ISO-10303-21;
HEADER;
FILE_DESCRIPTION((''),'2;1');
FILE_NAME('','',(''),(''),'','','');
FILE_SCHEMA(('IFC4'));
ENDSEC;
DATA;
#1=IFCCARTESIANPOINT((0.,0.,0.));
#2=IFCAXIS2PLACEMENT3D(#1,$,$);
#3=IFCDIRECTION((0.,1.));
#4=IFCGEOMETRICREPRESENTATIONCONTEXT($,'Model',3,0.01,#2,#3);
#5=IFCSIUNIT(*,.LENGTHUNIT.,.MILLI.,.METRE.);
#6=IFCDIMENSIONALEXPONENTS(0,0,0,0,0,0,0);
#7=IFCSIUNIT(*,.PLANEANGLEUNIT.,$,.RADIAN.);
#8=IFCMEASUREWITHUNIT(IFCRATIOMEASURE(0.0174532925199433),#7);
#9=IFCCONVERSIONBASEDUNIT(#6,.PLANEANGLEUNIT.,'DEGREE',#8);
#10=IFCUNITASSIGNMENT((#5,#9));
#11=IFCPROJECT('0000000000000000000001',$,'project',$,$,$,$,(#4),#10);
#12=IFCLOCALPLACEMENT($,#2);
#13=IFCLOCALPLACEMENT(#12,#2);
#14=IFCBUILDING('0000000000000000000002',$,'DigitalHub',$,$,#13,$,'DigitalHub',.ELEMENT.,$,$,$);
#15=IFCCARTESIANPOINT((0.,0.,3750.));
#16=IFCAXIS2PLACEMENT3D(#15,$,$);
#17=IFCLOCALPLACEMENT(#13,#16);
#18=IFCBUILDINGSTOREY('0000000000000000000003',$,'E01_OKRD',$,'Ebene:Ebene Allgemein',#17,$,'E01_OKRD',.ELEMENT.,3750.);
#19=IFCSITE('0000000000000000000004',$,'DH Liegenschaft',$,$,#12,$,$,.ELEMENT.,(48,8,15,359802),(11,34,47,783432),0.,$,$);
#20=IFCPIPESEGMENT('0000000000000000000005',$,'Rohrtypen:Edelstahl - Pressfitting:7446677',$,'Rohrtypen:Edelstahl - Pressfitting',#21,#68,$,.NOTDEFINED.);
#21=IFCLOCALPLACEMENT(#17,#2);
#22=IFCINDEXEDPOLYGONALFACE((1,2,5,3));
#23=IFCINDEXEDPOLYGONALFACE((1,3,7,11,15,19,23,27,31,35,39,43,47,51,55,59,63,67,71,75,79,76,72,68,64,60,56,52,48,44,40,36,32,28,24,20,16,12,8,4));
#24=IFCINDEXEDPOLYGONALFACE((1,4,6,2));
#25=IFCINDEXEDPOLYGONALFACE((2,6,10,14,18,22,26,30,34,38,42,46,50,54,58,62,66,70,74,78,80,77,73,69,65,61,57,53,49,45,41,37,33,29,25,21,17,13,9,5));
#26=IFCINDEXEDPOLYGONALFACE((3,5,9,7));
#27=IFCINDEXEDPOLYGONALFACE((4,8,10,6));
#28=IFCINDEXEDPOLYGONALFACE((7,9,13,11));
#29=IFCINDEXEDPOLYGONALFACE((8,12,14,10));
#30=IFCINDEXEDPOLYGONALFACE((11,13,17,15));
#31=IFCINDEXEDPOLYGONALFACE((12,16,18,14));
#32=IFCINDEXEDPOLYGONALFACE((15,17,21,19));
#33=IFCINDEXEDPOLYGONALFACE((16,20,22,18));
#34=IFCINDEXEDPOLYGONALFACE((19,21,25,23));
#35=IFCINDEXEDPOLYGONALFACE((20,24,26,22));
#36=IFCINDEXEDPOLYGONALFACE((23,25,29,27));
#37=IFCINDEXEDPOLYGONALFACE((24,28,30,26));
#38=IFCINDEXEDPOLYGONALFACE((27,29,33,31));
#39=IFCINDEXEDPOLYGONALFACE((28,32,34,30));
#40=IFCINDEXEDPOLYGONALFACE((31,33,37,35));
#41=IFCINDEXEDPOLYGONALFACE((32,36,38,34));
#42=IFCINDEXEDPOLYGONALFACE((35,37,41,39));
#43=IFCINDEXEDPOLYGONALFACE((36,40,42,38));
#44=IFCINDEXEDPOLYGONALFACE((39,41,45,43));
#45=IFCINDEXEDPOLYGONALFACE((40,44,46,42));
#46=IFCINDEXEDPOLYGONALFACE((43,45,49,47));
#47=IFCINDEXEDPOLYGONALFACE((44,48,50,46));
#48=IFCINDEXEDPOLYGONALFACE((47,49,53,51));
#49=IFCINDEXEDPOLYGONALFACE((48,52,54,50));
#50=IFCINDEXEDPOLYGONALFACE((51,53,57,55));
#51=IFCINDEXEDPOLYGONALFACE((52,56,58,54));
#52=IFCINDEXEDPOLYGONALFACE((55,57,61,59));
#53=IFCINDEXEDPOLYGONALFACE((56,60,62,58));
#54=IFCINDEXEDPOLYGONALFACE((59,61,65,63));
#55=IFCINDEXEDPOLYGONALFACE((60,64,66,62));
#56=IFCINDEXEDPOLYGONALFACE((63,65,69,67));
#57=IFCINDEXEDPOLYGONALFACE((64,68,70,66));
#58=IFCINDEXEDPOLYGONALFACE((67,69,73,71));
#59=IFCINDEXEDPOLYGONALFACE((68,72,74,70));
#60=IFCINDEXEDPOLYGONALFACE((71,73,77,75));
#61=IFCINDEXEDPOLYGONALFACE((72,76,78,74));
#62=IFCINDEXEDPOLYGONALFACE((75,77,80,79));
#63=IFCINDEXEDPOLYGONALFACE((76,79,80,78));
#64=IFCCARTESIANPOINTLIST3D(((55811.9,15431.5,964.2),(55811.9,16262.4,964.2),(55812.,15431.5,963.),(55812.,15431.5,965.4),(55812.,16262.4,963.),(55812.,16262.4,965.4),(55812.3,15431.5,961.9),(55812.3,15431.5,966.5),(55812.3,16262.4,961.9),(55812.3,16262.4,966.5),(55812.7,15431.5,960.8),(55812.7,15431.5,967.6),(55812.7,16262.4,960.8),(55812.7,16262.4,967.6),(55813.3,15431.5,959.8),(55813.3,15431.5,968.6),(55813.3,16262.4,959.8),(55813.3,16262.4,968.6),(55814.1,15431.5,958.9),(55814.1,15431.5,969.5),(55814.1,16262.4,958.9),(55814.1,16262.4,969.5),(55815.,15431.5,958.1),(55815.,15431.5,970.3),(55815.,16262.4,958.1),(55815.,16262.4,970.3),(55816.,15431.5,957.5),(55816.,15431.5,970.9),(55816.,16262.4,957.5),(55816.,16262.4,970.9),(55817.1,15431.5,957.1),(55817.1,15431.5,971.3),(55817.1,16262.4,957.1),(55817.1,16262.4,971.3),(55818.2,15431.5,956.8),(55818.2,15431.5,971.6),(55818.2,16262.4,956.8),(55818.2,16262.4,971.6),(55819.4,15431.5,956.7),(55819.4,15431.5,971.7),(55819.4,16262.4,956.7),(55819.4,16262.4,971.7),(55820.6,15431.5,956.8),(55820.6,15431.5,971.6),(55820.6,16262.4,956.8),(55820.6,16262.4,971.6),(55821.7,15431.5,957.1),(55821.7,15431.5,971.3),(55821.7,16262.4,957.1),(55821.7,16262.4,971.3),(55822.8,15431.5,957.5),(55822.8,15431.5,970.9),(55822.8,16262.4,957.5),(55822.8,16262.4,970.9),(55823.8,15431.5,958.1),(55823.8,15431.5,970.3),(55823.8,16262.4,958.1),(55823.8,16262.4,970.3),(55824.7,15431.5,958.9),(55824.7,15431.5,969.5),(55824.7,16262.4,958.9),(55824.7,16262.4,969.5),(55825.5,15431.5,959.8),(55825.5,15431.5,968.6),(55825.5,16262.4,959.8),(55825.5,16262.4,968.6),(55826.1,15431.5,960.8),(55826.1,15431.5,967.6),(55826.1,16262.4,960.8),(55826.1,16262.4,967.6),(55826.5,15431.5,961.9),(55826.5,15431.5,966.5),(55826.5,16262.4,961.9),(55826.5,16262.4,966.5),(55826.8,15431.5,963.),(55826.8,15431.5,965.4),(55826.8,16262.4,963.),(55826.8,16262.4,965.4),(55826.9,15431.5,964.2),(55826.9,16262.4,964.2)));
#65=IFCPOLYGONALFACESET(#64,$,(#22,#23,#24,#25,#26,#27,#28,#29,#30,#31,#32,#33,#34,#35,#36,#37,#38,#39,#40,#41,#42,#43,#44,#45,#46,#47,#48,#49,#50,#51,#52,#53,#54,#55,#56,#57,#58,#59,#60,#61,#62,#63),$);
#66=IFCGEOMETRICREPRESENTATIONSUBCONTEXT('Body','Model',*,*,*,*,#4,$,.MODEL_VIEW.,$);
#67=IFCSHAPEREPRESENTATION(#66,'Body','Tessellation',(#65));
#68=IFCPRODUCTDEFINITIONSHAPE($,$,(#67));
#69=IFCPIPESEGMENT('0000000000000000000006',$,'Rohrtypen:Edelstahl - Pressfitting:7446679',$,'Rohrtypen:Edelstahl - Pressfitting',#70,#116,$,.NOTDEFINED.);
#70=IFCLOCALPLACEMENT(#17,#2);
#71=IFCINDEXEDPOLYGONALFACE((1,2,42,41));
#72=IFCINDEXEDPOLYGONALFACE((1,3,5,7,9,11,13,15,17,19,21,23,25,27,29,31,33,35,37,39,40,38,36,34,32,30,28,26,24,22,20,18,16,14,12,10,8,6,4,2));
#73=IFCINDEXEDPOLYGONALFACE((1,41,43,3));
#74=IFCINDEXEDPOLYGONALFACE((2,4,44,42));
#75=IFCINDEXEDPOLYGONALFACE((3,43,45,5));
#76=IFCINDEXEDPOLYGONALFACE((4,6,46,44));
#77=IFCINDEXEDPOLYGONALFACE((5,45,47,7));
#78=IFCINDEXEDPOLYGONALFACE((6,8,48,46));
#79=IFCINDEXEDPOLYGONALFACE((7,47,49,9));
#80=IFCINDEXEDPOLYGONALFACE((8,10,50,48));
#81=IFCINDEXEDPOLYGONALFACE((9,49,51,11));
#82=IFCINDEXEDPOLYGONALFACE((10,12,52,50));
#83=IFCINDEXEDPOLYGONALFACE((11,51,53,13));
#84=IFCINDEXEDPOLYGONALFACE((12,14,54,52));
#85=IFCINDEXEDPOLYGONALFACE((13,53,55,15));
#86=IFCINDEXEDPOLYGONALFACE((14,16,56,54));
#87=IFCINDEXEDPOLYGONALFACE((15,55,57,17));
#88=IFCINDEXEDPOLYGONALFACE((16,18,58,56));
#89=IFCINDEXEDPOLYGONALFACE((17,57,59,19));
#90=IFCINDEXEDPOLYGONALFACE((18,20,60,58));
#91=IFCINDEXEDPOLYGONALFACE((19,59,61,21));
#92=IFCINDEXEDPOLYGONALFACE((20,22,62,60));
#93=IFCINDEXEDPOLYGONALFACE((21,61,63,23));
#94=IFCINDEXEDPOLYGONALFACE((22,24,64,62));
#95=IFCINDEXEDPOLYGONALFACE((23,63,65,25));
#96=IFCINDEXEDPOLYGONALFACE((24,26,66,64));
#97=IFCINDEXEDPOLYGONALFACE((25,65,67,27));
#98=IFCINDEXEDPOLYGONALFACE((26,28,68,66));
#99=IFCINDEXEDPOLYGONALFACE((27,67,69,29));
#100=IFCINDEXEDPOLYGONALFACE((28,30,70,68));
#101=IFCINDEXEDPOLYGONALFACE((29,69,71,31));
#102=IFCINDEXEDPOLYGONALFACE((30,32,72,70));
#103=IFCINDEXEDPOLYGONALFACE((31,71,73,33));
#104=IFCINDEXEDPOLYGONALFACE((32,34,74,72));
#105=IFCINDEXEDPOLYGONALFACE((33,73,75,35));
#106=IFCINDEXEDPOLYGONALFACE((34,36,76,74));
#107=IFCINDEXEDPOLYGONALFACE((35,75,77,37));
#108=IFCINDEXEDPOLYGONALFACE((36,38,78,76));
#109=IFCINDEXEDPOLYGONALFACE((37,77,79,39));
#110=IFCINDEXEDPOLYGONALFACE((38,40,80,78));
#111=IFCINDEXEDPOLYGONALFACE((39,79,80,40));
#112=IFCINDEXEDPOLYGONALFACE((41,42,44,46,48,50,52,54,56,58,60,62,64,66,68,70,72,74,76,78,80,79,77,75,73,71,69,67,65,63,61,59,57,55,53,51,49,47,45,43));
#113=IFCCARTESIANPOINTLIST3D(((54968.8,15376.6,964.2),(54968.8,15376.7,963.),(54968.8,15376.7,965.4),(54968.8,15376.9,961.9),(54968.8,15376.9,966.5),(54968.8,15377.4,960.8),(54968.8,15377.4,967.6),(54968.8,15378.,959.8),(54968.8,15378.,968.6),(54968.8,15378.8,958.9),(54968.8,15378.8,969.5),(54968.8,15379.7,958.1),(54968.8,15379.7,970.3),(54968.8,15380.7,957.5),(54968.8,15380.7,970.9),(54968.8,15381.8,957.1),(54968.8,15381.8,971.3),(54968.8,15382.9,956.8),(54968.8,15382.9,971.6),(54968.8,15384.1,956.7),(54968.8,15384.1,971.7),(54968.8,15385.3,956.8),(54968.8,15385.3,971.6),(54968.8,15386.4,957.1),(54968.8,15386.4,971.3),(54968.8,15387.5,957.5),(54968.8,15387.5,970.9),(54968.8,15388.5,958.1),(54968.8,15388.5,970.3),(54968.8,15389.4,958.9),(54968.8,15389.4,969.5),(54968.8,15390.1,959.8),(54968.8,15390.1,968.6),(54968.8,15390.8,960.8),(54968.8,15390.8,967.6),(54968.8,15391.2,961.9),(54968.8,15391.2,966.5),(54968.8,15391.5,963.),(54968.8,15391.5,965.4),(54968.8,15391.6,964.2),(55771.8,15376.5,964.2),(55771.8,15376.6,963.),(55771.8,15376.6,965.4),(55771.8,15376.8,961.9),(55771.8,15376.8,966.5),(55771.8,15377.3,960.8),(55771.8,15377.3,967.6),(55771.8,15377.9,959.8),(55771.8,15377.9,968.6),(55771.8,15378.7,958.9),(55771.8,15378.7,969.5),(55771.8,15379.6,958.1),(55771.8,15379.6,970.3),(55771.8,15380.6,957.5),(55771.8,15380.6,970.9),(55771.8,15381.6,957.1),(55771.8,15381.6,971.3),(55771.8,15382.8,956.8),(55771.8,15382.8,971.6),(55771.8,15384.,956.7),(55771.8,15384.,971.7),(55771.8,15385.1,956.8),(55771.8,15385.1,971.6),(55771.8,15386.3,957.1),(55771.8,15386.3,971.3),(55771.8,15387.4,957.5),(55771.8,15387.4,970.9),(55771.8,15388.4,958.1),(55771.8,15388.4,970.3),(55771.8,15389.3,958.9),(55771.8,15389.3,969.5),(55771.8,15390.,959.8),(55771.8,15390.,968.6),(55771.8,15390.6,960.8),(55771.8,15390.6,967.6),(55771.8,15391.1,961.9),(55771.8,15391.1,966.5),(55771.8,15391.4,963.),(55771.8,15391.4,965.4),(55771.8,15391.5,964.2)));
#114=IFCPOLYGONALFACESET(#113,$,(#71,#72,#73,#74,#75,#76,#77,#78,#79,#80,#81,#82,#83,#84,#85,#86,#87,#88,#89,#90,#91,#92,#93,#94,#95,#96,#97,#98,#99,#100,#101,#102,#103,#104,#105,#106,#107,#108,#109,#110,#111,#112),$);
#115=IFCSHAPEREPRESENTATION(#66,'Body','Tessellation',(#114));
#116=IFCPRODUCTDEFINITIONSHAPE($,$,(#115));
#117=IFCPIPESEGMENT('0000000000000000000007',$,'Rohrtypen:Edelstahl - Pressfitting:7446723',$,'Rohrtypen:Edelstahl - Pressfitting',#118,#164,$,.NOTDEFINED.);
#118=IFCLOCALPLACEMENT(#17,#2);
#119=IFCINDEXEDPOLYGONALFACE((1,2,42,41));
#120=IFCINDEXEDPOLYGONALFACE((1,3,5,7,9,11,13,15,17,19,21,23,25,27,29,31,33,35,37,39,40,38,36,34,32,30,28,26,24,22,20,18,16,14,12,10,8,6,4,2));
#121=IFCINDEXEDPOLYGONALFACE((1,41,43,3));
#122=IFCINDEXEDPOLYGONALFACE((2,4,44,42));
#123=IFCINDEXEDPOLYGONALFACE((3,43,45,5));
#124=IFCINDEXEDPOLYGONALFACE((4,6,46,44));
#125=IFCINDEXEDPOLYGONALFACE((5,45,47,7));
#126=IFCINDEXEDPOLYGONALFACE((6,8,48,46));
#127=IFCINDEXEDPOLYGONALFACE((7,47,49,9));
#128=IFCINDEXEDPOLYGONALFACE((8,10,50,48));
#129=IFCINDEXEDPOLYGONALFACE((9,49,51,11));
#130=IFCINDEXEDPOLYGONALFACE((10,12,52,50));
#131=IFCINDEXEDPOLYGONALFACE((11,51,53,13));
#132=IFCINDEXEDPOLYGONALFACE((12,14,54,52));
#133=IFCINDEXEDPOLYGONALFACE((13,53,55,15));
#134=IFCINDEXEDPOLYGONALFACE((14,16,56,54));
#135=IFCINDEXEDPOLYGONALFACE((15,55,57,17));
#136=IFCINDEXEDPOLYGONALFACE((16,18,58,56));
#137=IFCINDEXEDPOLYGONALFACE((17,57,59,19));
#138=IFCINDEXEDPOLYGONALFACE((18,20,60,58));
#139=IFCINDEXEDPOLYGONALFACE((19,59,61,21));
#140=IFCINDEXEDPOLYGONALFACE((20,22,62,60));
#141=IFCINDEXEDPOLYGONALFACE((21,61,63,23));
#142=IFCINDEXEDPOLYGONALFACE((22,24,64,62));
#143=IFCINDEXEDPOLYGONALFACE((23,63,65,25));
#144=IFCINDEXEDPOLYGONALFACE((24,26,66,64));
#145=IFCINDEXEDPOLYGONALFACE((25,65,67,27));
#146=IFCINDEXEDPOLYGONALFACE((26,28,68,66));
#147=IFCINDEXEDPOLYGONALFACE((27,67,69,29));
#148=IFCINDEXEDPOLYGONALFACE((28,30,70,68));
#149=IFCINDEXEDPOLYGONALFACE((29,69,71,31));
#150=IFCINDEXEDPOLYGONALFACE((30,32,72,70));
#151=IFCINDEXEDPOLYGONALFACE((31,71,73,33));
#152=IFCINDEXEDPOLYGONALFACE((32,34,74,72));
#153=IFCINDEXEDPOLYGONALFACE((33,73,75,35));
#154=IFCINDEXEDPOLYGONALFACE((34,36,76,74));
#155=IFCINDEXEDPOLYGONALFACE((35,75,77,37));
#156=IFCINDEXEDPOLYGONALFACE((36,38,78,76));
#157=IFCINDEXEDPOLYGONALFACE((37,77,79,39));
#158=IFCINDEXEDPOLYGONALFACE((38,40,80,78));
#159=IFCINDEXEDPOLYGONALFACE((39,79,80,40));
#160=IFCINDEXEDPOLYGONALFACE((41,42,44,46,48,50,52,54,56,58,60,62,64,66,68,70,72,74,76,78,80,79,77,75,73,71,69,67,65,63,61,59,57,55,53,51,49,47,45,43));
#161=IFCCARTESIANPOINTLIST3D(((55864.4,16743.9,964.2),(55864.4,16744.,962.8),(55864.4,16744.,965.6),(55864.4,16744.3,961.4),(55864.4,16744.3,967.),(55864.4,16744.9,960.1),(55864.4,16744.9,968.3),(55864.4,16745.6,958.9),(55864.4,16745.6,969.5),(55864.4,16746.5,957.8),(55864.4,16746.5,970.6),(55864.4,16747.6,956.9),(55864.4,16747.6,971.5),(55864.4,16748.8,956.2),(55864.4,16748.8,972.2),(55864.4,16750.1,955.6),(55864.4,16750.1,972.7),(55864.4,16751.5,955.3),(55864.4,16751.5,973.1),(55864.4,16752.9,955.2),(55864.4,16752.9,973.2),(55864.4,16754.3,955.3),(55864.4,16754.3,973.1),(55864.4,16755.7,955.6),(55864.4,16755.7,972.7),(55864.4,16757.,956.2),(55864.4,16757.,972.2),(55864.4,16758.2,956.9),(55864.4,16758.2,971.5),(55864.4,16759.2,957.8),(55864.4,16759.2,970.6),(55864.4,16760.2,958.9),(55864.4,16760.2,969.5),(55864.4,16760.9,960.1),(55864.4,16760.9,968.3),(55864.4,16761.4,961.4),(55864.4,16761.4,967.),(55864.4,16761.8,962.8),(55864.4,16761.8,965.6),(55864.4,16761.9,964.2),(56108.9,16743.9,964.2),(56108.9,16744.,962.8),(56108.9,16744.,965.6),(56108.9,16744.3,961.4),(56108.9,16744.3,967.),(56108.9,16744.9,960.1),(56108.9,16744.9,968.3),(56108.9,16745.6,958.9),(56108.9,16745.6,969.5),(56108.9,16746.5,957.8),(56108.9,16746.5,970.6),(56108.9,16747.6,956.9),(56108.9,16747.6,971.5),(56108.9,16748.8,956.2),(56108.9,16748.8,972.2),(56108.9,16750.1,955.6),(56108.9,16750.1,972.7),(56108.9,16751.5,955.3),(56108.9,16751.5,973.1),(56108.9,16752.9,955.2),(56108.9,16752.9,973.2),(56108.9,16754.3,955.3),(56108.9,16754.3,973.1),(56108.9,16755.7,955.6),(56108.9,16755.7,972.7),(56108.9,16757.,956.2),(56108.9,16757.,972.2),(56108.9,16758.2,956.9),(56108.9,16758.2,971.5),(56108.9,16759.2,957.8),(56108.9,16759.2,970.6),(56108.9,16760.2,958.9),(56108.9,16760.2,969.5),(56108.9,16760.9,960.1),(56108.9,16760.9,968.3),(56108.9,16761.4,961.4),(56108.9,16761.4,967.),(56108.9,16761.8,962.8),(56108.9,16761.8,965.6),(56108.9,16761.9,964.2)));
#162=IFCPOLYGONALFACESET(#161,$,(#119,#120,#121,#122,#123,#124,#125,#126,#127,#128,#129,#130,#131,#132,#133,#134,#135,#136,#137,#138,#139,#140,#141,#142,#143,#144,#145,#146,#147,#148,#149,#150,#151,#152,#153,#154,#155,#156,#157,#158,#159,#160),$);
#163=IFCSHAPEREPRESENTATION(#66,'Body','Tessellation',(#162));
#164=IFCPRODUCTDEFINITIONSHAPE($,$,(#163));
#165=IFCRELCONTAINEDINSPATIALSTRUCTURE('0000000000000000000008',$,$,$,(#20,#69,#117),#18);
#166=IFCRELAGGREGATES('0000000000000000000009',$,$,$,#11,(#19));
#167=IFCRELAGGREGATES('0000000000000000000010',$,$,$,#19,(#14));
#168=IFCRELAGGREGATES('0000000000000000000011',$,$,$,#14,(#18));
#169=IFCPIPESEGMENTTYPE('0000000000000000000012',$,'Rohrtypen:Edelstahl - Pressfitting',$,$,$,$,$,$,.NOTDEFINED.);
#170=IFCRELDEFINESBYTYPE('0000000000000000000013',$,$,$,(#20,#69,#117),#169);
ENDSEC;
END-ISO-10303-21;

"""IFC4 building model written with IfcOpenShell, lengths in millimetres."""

from ifc_helpers import new_model, entity, si_unit, converted_unit, direction, frame, origin, place, context, subcontext, project, spatial, indexed_curve, outline, extrude, type_object, element, save


model = new_model("IFC4")

# Units and contexts
model_context = context("Model", 3, precision=0.01, world=origin(), true_north=direction((0.0, 1.0)))
body_context = subcontext(model_context, "Body", "Model", "MODEL_VIEW")
ifc_project = project(units=[si_unit("LENGTHUNIT", "METRE", prefix="MILLI"), converted_unit("PLANEANGLEUNIT", "DEGREE", entity("IfcRatioMeasure", 0.0174532925199433), si_unit("PLANEANGLEUNIT", "RADIAN"), dimensions=[0, 0, 0, 0, 0, 0, 0])], contexts=[model_context])

# Site, building, storey
site_placement = place(None, origin())
site = spatial("IfcSite", under=ifc_project, at=site_placement, Name="DH Liegenschaft", CompositionType="ELEMENT", RefLatitude=(48, 8, 15, 359802), RefLongitude=(11, 34, 47, 783432), RefElevation=0.0)
building_placement = place(site_placement, origin())
building = spatial("IfcBuilding", under=site, at=building_placement, Name="DigitalHub", LongName="DigitalHub", CompositionType="ELEMENT")
storey_placement = place(building_placement, frame((0.0, 0.0, 3750.0)))
storey = spatial("IfcBuildingStorey", under=building, at=storey_placement, Name="E01_OKRD", ObjectType="Ebene:Ebene Allgemein", LongName="E01_OKRD", CompositionType="ELEMENT", Elevation=3750.0)

# Pipe segments
pipe_segment_type_1 = type_object("IfcPipeSegmentType", Name="Rohrtypen:Edelstahl - Pressfitting", PredefinedType="NOTDEFINED")
pipe_segment_1_placement = place(storey_placement, frame((55810.3, 15431.5, 955.1)))
element("IfcPipeSegment", 1, at=pipe_segment_1_placement, inside=storey, type_object=pipe_segment_type_1, Name="Rohrtypen:Edelstahl - Pressfitting:7446677", ObjectType="Rohrtypen:Edelstahl - Pressfitting", PredefinedType="NOTDEFINED", context=body_context, shape_type="SweptSolid", body=[
    extrude(outline(indexed_curve([(7.5, 0.0), (7.4, 1.2), (7.1, 2.3), (6.7, 3.4), (6.1, 4.4), (5.3, 5.3), (4.4, 6.1), (3.4, 6.7), (2.3, 7.1), (1.2, 7.4), (0.0, 7.5), (-1.2, 7.4), (-2.3, 7.1), (-3.4, 6.7), (-4.4, 6.1), (-5.3, 5.3), (-6.1, 4.4), (-6.7, 3.4), (-7.1, 2.3), (-7.4, 1.2), (-7.5, 0.0), (-7.4, -1.2), (-7.1, -2.3), (-6.7, -3.4), (-6.1, -4.4), (-5.3, -5.3), (-4.4, -6.1), (-3.4, -6.7), (-2.3, -7.1), (-1.2, -7.4), (0.0, -7.5), (1.2, -7.4), (2.3, -7.1), (3.4, -6.7), (4.4, -6.1), (5.3, -5.3), (6.1, -4.4), (6.7, -3.4), (7.1, -2.3), (7.4, -1.2), (7.5, 0.0)], self_intersect=False)), frame((9.1, 0.0, 9.1), z_axis=(-0.000004, 1.0, 0.0), x_axis=(-1.0, -0.000004, 0.0)), (0.0, 0.0, 1.0), 830.9),
])
pipe_segment_2_placement = place(storey_placement, frame((54968.8, 15374.9, 955.1)))
element("IfcPipeSegment", 2, at=pipe_segment_2_placement, inside=storey, type_object=pipe_segment_type_1, Name="Rohrtypen:Edelstahl - Pressfitting:7446679", ObjectType="Rohrtypen:Edelstahl - Pressfitting", PredefinedType="NOTDEFINED", context=body_context, shape_type="SweptSolid", body=[
    extrude(outline(indexed_curve([(7.5, 0.0), (7.4, 1.2), (7.1, 2.3), (6.7, 3.4), (6.1, 4.4), (5.3, 5.3), (4.4, 6.1), (3.4, 6.7), (2.3, 7.1), (1.2, 7.4), (0.0, 7.5), (-1.2, 7.4), (-2.3, 7.1), (-3.4, 6.7), (-4.4, 6.1), (-5.3, 5.3), (-6.1, 4.4), (-6.7, 3.4), (-7.1, 2.3), (-7.4, 1.2), (-7.5, 0.0), (-7.4, -1.2), (-7.1, -2.3), (-6.7, -3.4), (-6.1, -4.4), (-5.3, -5.3), (-4.4, -6.1), (-3.4, -6.7), (-2.3, -7.1), (-1.2, -7.4), (0.0, -7.5), (1.2, -7.4), (2.3, -7.1), (3.4, -6.7), (4.4, -6.1), (5.3, -5.3), (6.1, -4.4), (6.7, -3.4), (7.1, -2.3), (7.4, -1.2), (7.5, 0.0)], self_intersect=False)), frame((0.0, 9.2, 9.1), z_axis=(1.0, -0.000148, 0.0), x_axis=(0.000148, 1.0, 0.0)), (0.0, 0.0, 1.0), 803.0),
])
pipe_segment_3_placement = place(storey_placement, frame((55864.4, 16742.3, 953.6)))
element("IfcPipeSegment", 3, at=pipe_segment_3_placement, inside=storey, type_object=pipe_segment_type_1, Name="Rohrtypen:Edelstahl - Pressfitting:7446723", ObjectType="Rohrtypen:Edelstahl - Pressfitting", PredefinedType="NOTDEFINED", context=body_context, shape_type="SweptSolid", body=[
    extrude(outline(indexed_curve([(9.0, 0.0), (8.9, 1.4), (8.6, 2.8), (8.0, 4.1), (7.3, 5.3), (6.4, 6.4), (5.3, 7.3), (4.1, 8.0), (2.8, 8.6), (1.4, 8.9), (0.0, 9.0), (-1.4, 8.9), (-2.8, 8.6), (-4.1, 8.0), (-5.3, 7.3), (-6.4, 6.4), (-7.3, 5.3), (-8.0, 4.1), (-8.6, 2.8), (-8.9, 1.4), (-9.0, 0.0), (-8.9, -1.4), (-8.6, -2.8), (-8.0, -4.1), (-7.3, -5.3), (-6.4, -6.4), (-5.3, -7.3), (-4.1, -8.0), (-2.8, -8.6), (-1.4, -8.9), (0.0, -9.0), (1.4, -8.9), (2.8, -8.6), (4.1, -8.0), (5.3, -7.3), (6.4, -6.4), (7.3, -5.3), (8.0, -4.1), (8.6, -2.8), (8.9, -1.4), (9.0, 0.0)], self_intersect=False)), frame((0.0, 10.6, 10.6), z_axis=(1.0, 0.0, 0.0), x_axis=(0.0, -1.0, 0.0)), (0.0, 0.0, 1.0), 244.5),
])

save(model, "model.ifc")
